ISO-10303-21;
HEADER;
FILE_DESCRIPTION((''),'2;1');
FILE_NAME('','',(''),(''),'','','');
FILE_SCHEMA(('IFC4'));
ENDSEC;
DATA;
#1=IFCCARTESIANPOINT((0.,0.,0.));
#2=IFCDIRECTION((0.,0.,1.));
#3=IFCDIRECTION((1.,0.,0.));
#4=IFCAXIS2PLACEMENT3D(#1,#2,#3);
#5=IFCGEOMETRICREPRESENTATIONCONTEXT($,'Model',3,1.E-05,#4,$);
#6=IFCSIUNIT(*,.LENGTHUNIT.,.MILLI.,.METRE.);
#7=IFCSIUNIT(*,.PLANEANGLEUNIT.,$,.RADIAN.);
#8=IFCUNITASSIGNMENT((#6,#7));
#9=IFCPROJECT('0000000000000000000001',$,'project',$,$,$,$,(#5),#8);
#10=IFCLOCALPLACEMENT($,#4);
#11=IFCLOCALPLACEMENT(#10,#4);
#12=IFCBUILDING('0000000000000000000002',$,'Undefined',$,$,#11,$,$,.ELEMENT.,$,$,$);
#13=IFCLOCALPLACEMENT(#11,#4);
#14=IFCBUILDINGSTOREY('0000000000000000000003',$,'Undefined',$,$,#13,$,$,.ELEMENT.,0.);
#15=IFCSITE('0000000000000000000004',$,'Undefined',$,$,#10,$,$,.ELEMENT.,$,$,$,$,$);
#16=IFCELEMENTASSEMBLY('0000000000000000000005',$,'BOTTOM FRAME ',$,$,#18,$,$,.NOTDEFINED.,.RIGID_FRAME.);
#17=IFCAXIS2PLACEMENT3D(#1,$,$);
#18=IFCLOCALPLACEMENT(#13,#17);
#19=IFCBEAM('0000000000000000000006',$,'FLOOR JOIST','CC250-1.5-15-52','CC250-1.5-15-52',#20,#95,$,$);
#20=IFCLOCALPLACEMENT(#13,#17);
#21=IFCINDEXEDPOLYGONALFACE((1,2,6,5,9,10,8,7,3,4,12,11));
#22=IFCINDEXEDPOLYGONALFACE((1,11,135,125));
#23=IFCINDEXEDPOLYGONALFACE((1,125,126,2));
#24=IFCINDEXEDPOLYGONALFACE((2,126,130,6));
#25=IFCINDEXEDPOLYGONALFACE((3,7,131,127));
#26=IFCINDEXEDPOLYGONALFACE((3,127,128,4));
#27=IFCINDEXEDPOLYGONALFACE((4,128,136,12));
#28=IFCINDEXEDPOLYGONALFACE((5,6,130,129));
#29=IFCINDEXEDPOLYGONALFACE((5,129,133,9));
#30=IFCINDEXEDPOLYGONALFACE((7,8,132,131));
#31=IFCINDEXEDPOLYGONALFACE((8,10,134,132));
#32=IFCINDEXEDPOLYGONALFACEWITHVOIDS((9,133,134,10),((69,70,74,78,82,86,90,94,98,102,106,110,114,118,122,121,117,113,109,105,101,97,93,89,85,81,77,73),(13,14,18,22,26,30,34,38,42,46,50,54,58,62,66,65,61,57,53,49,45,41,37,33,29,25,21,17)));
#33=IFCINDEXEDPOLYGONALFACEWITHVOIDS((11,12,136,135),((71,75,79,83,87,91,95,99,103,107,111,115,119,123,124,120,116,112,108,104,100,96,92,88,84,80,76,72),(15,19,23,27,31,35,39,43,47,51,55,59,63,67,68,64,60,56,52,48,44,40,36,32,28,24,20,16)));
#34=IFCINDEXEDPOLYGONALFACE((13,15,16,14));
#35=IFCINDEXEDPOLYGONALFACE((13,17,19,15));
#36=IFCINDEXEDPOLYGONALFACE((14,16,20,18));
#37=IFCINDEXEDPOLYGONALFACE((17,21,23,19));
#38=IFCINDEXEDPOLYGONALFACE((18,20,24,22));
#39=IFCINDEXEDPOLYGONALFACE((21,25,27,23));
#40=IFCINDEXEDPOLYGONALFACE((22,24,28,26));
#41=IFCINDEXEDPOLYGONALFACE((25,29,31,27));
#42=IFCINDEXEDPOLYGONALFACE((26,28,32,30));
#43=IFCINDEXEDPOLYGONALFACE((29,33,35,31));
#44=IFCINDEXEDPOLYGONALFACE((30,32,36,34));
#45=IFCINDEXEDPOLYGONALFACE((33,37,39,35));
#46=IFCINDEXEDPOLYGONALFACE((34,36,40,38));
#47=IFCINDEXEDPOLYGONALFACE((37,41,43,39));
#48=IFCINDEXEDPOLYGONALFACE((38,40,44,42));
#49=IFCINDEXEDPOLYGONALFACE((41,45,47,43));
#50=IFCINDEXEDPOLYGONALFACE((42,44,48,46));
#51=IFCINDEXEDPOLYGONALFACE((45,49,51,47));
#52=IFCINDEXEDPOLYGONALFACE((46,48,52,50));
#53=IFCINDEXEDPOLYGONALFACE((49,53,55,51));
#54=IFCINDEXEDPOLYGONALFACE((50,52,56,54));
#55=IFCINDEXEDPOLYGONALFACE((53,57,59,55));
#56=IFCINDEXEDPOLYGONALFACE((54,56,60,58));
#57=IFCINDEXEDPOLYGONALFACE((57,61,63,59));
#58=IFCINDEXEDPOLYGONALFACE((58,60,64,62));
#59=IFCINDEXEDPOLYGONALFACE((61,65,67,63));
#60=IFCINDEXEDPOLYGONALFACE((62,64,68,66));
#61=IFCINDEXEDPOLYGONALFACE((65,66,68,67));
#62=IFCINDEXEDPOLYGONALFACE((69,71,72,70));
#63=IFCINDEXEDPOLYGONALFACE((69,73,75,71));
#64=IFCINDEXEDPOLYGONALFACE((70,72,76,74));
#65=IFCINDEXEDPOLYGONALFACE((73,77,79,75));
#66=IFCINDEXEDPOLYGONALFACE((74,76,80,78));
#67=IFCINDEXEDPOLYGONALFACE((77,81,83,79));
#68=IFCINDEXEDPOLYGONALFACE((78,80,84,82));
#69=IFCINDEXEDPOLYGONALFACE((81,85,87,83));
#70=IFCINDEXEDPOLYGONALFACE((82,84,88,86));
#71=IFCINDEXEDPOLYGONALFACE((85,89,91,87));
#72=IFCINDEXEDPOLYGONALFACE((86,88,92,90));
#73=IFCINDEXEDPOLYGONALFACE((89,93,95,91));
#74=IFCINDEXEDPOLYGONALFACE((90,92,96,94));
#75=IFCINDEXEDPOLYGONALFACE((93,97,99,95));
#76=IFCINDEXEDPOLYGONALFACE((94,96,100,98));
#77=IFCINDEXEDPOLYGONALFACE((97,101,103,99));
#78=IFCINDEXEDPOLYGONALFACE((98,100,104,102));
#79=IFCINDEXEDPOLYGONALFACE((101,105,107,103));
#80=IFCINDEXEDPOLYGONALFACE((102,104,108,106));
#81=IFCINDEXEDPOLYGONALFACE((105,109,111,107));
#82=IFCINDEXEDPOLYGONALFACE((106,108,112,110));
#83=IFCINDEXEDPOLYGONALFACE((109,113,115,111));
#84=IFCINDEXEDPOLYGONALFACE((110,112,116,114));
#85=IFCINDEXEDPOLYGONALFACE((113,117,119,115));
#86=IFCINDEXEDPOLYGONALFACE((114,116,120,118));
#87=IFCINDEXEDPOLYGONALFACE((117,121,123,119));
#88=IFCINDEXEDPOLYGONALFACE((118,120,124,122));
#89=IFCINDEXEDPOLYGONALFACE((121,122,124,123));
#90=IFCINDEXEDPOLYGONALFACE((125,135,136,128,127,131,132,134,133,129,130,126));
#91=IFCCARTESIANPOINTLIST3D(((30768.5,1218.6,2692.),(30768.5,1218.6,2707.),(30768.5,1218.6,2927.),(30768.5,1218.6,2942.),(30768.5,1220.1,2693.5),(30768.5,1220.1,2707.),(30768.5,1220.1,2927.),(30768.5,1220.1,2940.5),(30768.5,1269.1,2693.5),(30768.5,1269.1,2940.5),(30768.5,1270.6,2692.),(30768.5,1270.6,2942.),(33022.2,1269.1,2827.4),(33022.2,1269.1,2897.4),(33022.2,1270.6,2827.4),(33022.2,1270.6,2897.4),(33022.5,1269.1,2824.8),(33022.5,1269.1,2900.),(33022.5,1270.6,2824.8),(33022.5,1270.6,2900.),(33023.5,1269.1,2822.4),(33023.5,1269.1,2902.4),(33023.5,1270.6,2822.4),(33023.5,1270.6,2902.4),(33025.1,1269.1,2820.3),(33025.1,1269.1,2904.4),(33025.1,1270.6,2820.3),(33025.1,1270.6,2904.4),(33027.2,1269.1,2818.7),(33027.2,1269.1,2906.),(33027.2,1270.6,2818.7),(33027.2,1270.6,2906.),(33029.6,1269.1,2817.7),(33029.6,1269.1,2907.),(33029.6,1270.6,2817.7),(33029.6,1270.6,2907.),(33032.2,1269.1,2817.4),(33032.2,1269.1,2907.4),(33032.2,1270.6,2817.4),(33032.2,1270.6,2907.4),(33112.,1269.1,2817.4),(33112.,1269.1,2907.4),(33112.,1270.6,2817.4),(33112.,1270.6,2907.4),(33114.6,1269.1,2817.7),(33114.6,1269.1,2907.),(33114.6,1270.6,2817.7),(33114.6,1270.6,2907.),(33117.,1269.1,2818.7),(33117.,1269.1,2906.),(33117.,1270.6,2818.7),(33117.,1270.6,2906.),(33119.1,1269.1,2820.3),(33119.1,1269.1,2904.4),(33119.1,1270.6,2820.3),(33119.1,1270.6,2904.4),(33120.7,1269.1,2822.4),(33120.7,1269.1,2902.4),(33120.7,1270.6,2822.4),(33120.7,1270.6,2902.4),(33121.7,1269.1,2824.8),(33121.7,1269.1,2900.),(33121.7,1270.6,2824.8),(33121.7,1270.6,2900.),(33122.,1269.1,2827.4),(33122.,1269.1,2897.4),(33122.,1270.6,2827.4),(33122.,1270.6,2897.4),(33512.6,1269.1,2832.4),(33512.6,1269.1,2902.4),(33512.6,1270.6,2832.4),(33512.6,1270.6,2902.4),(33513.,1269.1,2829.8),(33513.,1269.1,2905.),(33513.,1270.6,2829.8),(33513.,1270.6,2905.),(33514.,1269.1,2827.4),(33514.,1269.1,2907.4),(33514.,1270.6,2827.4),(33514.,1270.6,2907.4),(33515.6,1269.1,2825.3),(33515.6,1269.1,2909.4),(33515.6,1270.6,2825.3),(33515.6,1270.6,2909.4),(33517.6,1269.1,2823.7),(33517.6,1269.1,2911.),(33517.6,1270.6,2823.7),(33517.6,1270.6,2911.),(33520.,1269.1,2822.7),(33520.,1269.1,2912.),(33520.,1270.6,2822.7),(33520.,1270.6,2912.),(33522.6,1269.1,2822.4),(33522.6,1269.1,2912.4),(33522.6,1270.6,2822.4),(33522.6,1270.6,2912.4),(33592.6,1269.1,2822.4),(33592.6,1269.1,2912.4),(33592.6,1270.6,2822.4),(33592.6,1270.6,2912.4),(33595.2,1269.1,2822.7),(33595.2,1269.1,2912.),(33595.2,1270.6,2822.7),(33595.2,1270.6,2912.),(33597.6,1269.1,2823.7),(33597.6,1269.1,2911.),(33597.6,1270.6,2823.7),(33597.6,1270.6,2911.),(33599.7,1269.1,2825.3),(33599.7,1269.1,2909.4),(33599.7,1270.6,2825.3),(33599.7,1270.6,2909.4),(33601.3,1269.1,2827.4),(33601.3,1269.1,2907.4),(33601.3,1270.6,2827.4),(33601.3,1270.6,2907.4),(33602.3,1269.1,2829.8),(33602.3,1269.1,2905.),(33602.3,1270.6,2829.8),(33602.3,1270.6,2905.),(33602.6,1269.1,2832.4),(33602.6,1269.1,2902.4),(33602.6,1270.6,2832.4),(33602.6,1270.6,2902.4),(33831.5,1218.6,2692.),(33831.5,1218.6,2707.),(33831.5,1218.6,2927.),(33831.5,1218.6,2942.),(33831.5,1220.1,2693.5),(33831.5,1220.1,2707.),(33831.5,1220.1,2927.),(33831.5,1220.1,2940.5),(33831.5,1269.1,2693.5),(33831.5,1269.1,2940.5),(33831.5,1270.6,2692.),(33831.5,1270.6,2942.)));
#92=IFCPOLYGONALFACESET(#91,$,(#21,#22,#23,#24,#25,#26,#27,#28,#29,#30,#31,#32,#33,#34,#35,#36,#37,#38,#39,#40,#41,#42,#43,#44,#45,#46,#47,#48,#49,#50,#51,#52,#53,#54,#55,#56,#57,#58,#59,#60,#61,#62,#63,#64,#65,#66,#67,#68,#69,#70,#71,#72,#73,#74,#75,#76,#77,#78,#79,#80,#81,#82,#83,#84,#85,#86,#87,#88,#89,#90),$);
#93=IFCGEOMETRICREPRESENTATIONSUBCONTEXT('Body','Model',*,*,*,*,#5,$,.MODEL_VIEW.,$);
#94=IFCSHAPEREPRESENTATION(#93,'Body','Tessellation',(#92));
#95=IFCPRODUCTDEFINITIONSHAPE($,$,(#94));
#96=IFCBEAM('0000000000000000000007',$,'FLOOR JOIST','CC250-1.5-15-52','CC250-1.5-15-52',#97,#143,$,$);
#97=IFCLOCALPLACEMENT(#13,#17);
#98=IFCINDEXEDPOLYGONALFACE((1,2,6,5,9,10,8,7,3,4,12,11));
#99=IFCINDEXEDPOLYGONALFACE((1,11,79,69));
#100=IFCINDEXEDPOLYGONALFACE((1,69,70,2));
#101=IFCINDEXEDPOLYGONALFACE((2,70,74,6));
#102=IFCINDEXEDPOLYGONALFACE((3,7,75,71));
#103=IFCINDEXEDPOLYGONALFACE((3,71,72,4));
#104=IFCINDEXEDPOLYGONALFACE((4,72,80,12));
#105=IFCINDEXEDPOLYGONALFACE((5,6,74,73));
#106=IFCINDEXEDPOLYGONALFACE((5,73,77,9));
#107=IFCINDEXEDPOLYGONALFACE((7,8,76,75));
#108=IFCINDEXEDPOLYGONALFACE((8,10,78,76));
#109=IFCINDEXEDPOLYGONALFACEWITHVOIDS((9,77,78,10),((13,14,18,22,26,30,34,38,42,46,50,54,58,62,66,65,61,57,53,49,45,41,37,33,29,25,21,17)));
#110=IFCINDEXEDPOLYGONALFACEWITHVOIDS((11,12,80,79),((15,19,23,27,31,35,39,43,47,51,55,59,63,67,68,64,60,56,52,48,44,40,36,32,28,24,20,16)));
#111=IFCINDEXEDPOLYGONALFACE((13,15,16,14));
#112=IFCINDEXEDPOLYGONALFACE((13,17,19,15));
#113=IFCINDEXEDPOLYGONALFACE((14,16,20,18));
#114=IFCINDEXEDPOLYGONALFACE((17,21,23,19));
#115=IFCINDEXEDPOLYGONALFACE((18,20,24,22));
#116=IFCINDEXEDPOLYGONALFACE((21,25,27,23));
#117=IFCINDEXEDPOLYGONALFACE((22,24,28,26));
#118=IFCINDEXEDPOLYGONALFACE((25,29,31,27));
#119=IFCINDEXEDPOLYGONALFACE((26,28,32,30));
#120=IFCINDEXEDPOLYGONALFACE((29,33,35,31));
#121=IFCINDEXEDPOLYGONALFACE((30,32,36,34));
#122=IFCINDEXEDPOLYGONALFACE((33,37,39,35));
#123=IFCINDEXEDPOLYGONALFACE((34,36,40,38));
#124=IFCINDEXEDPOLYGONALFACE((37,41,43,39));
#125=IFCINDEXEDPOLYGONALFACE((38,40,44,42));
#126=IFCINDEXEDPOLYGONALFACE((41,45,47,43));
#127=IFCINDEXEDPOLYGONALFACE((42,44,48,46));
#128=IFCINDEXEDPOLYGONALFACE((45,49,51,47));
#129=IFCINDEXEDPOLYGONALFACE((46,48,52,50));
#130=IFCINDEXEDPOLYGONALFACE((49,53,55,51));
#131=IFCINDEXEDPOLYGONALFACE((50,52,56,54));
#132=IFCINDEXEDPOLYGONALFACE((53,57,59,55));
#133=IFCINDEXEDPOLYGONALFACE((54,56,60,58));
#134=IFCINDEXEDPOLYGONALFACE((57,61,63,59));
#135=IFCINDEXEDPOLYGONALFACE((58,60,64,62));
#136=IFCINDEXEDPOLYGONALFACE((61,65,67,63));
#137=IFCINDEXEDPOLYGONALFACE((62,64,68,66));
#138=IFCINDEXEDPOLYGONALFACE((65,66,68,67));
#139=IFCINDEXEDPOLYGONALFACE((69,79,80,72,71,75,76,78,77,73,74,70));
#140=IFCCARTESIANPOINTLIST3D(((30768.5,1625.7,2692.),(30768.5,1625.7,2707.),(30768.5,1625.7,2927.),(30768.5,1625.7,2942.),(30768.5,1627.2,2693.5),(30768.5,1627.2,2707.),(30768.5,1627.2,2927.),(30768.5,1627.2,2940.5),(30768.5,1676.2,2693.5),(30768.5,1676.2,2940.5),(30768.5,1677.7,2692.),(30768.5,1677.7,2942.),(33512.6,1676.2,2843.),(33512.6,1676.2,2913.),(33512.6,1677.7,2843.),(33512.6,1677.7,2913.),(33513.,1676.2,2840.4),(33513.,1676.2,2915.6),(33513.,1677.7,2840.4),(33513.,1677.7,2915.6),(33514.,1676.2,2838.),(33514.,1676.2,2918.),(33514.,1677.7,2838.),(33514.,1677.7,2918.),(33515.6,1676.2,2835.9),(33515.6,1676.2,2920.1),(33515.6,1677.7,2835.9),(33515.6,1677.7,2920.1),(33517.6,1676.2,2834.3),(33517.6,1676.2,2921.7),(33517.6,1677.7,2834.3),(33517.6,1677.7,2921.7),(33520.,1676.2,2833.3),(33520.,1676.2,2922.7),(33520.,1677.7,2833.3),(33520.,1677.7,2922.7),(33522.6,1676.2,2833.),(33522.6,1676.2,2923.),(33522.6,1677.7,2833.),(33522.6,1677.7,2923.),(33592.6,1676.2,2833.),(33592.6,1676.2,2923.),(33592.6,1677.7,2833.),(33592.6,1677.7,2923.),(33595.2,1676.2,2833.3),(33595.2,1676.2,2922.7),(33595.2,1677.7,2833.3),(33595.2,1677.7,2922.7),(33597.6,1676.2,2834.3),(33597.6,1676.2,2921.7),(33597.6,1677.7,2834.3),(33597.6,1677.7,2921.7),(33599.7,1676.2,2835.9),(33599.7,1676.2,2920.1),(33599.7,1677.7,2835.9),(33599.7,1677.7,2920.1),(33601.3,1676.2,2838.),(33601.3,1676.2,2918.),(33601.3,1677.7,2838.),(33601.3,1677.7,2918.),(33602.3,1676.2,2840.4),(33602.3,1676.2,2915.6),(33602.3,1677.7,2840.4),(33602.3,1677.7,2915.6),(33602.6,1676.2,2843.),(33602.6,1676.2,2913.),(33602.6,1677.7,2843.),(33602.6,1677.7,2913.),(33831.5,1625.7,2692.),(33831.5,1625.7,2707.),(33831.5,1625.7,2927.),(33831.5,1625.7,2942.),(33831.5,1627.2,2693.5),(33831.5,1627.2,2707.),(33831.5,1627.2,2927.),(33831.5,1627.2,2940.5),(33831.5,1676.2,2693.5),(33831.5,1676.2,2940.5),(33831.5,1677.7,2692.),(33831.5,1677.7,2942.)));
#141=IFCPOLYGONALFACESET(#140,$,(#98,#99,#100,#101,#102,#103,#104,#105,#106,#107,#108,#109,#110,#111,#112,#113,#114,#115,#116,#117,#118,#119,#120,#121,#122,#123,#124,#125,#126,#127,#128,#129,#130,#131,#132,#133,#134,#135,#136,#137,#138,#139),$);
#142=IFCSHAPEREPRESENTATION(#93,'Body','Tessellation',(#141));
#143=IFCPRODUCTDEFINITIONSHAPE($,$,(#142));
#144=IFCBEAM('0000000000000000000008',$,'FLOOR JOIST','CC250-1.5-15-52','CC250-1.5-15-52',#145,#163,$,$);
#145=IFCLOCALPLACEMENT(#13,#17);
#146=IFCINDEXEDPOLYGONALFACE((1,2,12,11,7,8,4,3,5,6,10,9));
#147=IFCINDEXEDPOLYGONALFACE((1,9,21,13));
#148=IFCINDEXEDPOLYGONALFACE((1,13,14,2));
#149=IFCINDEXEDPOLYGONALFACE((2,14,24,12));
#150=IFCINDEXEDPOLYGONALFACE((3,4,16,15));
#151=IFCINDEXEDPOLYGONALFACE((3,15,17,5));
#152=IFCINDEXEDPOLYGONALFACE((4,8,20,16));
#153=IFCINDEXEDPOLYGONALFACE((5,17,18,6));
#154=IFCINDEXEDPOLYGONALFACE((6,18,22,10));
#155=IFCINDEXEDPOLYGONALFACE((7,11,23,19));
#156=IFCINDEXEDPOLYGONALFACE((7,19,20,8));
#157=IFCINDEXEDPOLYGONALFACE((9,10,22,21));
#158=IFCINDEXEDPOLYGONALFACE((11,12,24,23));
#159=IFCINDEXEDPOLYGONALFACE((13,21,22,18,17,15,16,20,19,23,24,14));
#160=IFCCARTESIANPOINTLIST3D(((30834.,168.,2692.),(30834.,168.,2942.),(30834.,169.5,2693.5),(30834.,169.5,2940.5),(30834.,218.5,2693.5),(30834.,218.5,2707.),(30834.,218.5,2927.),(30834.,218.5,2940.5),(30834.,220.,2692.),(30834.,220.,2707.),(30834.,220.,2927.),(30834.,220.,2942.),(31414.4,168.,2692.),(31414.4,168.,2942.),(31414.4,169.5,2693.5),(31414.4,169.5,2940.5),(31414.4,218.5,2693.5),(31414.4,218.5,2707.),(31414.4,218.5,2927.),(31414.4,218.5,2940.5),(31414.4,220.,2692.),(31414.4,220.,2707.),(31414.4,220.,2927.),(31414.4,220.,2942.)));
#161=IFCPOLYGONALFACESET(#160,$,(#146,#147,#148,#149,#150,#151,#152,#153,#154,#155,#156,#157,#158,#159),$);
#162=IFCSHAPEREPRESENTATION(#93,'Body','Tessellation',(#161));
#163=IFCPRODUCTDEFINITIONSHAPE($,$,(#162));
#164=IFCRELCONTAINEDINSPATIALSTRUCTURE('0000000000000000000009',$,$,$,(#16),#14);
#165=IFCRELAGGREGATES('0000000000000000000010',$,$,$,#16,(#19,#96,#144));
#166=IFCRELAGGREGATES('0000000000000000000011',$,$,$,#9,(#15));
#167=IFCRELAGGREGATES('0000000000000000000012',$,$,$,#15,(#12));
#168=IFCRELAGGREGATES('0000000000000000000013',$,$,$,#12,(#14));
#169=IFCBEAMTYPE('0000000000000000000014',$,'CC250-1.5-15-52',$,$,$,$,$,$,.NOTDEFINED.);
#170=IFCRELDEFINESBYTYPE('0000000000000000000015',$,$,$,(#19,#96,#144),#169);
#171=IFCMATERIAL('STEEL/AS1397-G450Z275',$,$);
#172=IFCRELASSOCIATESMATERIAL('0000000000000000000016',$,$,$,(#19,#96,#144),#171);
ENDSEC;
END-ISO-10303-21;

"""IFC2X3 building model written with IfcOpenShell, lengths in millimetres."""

from ifc_helpers import new_model, si_unit, frame, frame_2d, origin_with_axes, origin_2d_with_axis, place, context, subcontext, project, spatial, polyline, circle_curve, parameter, trimmed, segment, composite_curve, c_section, outline, extrude, boolean, material, type_object, element, aggregate, save


model = new_model("IFC2X3")

# Units and contexts
model_context = context("Model", 3, precision=1e-05, world=origin_with_axes())
body_context = subcontext(model_context, "Body", "Model", "MODEL_VIEW")
ifc_project = project(units=[si_unit("LENGTHUNIT", "METRE", prefix="MILLI"), si_unit("PLANEANGLEUNIT", "RADIAN")], contexts=[model_context])

# Site, building, storey
site_placement = place(None, origin_with_axes())
site = spatial("IfcSite", under=ifc_project, at=site_placement, Name="Undefined", CompositionType="ELEMENT")
building_placement = place(site_placement, origin_with_axes())
building = spatial("IfcBuilding", under=site, at=building_placement, Name="Undefined", CompositionType="ELEMENT")
storey_placement = place(building_placement, origin_with_axes())
storey = spatial("IfcBuildingStorey", under=building, at=storey_placement, Name="Undefined", CompositionType="ELEMENT", Elevation=0.0)

# Element assembly, beams
assembly_1_placement = place(storey_placement, origin_with_axes())
assembly_1 = element("IfcElementAssembly", 1, at=assembly_1_placement, inside=storey, Name="BOTTOM FRAME ", AssemblyPlace="NOTDEFINED", PredefinedType="RIGID_FRAME")
ifc_material_1 = material(Name="STEEL/AS1397-G450Z275")
beam_type_1 = type_object("IfcBeamType", Name="CC250-1.5-15-52", PredefinedType="NOTDEFINED")
beam_1_placement = place(assembly_1_placement, frame((30768.5, 1244.6, 2817.0), z_axis=(0.0, 0.0, 1.0), x_axis=(1.0, 0.0, 0.0)))
beam_1 = element("IfcBeam", 2, at=beam_1_placement, type_object=beam_type_1, material=ifc_material_1, Name="FLOOR JOIST", Description="CC250-1.5-15-52", ObjectType="CC250-1.5-15-52", context=body_context, shape_type="CSG", body=[
    boolean("DIFFERENCE", boolean("DIFFERENCE", extrude(c_section(Depth=250.0, Width=52.0, WallThickness=1.5, Girth=15.0, at=origin_2d_with_axis()), frame((3063.0, 0.0, 0.0), z_axis=(-1.0, 0.0, 0.0), x_axis=(0.0, -1.0, 0.0)), (0.0, 0.0, 1.0), 3063.0), extrude(outline(composite_curve([segment(trimmed(circle_curve(frame_2d((10.0, 10.0), x_axis=(-1.0, 0.0)), 10.0), [parameter(0.0)], [parameter(1.570796)], True, "PARAMETER"), True, "CONTINUOUS"), segment(polyline([(10.0, 0.0), (89.8, 0.0)]), True, "CONTINUOUS"), segment(trimmed(circle_curve(frame_2d((89.8, 10.0), x_axis=(0.0, -1.0)), 10.0), [parameter(0.0)], [parameter(1.570796)], True, "PARAMETER"), True, "CONTINUOUS"), segment(polyline([(99.8, 10.0), (99.8, 80.0)]), True, "CONTINUOUS"), segment(trimmed(circle_curve(frame_2d((89.8, 80.0), x_axis=(1.0, 0.0)), 10.0), [parameter(0.0)], [parameter(1.570796)], True, "PARAMETER"), True, "CONTINUOUS"), segment(polyline([(89.8, 90.0), (10.0, 90.0)]), True, "CONTINUOUS"), segment(trimmed(circle_curve(frame_2d((10.0, 80.0), x_axis=(0.0, 1.0)), 10.0), [parameter(0.0)], [parameter(1.570796)], True, "PARAMETER"), True, "CONTINUOUS"), segment(polyline([(0.0, 80.0), (0.0, 10.0)]), True, "CONTINUOUS")], self_intersect=True)), frame((2253.7, -40.5, 90.4), z_axis=(0.0, 1.0, 0.0), x_axis=(1.0, 0.0, 0.0)), (0.0, 0.0, 1.0), 81.0)), extrude(outline(composite_curve([segment(trimmed(circle_curve(frame_2d((10.0, 10.0), x_axis=(-1.0, 0.0)), 10.0), [parameter(0.0)], [parameter(1.570796)], True, "PARAMETER"), True, "CONTINUOUS"), segment(polyline([(10.0, 0.0), (80.0, 0.0)]), True, "CONTINUOUS"), segment(trimmed(circle_curve(frame_2d((80.0, 10.0), x_axis=(0.0, -1.0)), 10.0), [parameter(0.0)], [parameter(1.570796)], True, "PARAMETER"), True, "CONTINUOUS"), segment(polyline([(90.0, 10.0), (90.0, 80.0)]), True, "CONTINUOUS"), segment(trimmed(circle_curve(frame_2d((80.0, 80.0), x_axis=(1.0, 0.0)), 10.0), [parameter(0.0)], [parameter(1.570796)], True, "PARAMETER"), True, "CONTINUOUS"), segment(polyline([(80.0, 90.0), (10.0, 90.0)]), True, "CONTINUOUS"), segment(trimmed(circle_curve(frame_2d((10.0, 80.0), x_axis=(0.0, 1.0)), 10.0), [parameter(0.0)], [parameter(1.570796)], True, "PARAMETER"), True, "CONTINUOUS"), segment(polyline([(0.0, 80.0), (0.0, 10.0)]), True, "CONTINUOUS")], self_intersect=True)), frame((2744.1, -40.5, 95.4), z_axis=(0.0, 1.0, 0.0), x_axis=(1.0, 0.0, 0.0)), (0.0, 0.0, 1.0), 81.0)),
])
beam_2_placement = place(assembly_1_placement, frame((30768.5, 1651.7, 2817.0), z_axis=(0.0, 0.0, 1.0), x_axis=(1.0, 0.0, 0.0)))
beam_2 = element("IfcBeam", 3, at=beam_2_placement, type_object=beam_type_1, material=ifc_material_1, Name="FLOOR JOIST", Description="CC250-1.5-15-52", ObjectType="CC250-1.5-15-52", context=body_context, shape_type="CSG", body=[
    boolean("DIFFERENCE", extrude(c_section(Depth=250.0, Width=52.0, WallThickness=1.5, Girth=15.0, at=origin_2d_with_axis()), frame((3063.0, 0.0, 0.0), z_axis=(-1.0, 0.0, 0.0), x_axis=(0.0, -1.0, 0.0)), (0.0, 0.0, 1.0), 3063.0), extrude(outline(composite_curve([segment(trimmed(circle_curve(frame_2d((10.0, 10.0), x_axis=(-1.0, 0.0)), 10.0), [parameter(0.0)], [parameter(1.570796)], True, "PARAMETER"), True, "CONTINUOUS"), segment(polyline([(10.0, 0.0), (80.0, 0.0)]), True, "CONTINUOUS"), segment(trimmed(circle_curve(frame_2d((80.0, 10.0), x_axis=(0.0, -1.0)), 10.0), [parameter(0.0)], [parameter(1.570796)], True, "PARAMETER"), True, "CONTINUOUS"), segment(polyline([(90.0, 10.0), (90.0, 80.0)]), True, "CONTINUOUS"), segment(trimmed(circle_curve(frame_2d((80.0, 80.0), x_axis=(1.0, 0.0)), 10.0), [parameter(0.0)], [parameter(1.570796)], True, "PARAMETER"), True, "CONTINUOUS"), segment(polyline([(80.0, 90.0), (10.0, 90.0)]), True, "CONTINUOUS"), segment(trimmed(circle_curve(frame_2d((10.0, 80.0), x_axis=(0.0, 1.0)), 10.0), [parameter(0.0)], [parameter(1.570796)], True, "PARAMETER"), True, "CONTINUOUS"), segment(polyline([(0.0, 80.0), (0.0, 10.0)]), True, "CONTINUOUS")], self_intersect=True)), frame((2744.1, -40.5, 106.0), z_axis=(0.0, 1.0, 0.0), x_axis=(1.0, 0.0, 0.0)), (0.0, 0.0, 1.0), 81.0)),
])
beam_3_placement = place(assembly_1_placement, frame((31414.4, 194.0, 2817.0), z_axis=(0.0, 0.0, 1.0), x_axis=(-1.0, 0.0, 0.0)))
beam_3 = element("IfcBeam", 4, at=beam_3_placement, type_object=beam_type_1, material=ifc_material_1, Name="FLOOR JOIST", Description="CC250-1.5-15-52", ObjectType="CC250-1.5-15-52", context=body_context, shape_type="SweptSolid", body=[
    extrude(c_section(Depth=250.0, Width=52.0, WallThickness=1.5, Girth=15.0, at=origin_2d_with_axis()), frame((580.4, 0.0, 0.0), z_axis=(-1.0, 0.0, 0.0), x_axis=(0.0, -1.0, 0.0)), (0.0, 0.0, 1.0), 580.4),
])
aggregate(assembly_1, [beam_1, beam_2, beam_3])

save(model, "model.ifc")
